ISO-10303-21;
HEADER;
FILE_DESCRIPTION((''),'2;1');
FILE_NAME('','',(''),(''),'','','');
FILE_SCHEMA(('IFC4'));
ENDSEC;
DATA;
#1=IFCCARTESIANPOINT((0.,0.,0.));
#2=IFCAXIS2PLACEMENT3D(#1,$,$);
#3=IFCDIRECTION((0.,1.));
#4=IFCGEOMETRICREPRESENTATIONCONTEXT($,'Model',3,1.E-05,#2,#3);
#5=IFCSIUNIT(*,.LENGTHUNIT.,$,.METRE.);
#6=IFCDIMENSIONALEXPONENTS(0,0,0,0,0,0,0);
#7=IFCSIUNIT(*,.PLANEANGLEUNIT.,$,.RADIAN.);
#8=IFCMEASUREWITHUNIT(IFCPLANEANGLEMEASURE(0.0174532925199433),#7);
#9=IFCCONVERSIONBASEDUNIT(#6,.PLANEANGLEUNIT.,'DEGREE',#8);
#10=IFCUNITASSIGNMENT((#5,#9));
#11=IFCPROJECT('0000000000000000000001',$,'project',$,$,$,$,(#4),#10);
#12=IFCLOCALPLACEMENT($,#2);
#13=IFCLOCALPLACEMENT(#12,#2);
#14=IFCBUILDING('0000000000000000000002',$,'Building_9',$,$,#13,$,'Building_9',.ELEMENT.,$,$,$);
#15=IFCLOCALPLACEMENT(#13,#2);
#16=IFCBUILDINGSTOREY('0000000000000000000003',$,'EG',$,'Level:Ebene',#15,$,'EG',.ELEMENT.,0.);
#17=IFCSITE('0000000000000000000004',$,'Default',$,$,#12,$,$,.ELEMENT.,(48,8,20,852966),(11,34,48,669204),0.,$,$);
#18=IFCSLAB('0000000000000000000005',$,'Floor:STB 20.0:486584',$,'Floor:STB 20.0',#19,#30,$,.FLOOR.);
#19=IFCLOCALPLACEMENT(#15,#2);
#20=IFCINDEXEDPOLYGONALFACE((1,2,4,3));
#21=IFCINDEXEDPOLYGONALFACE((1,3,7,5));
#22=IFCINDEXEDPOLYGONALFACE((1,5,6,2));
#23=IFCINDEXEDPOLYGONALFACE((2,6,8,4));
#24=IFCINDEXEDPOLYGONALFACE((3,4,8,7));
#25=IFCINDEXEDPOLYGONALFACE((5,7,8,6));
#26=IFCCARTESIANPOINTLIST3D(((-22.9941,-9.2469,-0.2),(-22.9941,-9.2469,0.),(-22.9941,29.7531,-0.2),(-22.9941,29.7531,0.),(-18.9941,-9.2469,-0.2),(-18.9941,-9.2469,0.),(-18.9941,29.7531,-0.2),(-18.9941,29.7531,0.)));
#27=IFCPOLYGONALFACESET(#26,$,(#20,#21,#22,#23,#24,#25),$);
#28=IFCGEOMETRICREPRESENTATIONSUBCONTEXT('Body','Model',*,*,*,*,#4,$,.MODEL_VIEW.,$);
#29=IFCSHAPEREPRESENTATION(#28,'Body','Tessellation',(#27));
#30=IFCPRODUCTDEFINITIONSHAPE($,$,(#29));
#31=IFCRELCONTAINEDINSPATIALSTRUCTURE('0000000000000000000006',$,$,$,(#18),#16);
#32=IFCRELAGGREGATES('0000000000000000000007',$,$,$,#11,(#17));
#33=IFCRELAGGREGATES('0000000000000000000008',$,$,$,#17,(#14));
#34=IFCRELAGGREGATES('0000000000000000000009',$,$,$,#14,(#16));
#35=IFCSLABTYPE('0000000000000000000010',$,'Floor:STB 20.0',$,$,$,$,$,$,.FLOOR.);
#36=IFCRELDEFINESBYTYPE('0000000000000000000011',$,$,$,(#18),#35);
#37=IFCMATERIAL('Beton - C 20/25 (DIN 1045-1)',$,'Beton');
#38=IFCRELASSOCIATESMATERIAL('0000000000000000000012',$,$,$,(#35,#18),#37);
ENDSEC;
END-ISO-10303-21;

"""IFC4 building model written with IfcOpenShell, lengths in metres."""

from ifc_helpers import new_model, entity, si_unit, converted_unit, direction, frame, origin, place, context, subcontext, project, spatial, indexed_curve, outline, extrude, material, type_object, element, save


model = new_model("IFC4")

# Units and contexts
model_context = context("Model", 3, precision=1e-05, world=origin(), true_north=direction((0.0, 1.0)))
body_context = subcontext(model_context, "Body", "Model", "MODEL_VIEW")
ifc_project = project(units=[si_unit("LENGTHUNIT", "METRE"), converted_unit("PLANEANGLEUNIT", "DEGREE", entity("IfcPlaneAngleMeasure", 0.0174532925199433), si_unit("PLANEANGLEUNIT", "RADIAN"), dimensions=[0, 0, 0, 0, 0, 0, 0])], contexts=[model_context])

# Site, building, storey
site_placement = place(None, origin())
site = spatial("IfcSite", under=ifc_project, at=site_placement, Name="Default", CompositionType="ELEMENT", RefLatitude=(48, 8, 20, 852966), RefLongitude=(11, 34, 48, 669204), RefElevation=0.0)
building_placement = place(site_placement, origin())
building = spatial("IfcBuilding", under=site, at=building_placement, Name="Building_9", LongName="Building_9", CompositionType="ELEMENT")
storey_placement = place(building_placement, origin())
storey = spatial("IfcBuildingStorey", under=building, at=storey_placement, Name="EG", ObjectType="Level:Ebene", LongName="EG", CompositionType="ELEMENT", Elevation=0.0)

# Slab
ifc_material_1 = material(Name="Beton - C 20/25 (DIN 1045-1)", Category="Beton")
slab_type = type_object("IfcSlabType", Name="Floor:STB 20.0", PredefinedType="FLOOR", material=ifc_material_1)
slab_1_placement = place(storey_placement, origin())
element("IfcSlab", 1, at=slab_1_placement, inside=storey, type_object=slab_type, material=ifc_material_1, Name="Floor:STB 20.0:486584", ObjectType="Floor:STB 20.0", PredefinedType="FLOOR", context=body_context, shape_type="SweptSolid", body=[
    extrude(outline(indexed_curve([(-19.5, -2.0), (19.5, -2.0), (19.5, 2.0), (-19.5, 2.0), (-19.5, -2.0)], self_intersect=False)), frame((-20.9941, 10.2531, 0.0), z_axis=(0.0, 0.0, -1.0), x_axis=(0.0, 1.0, 0.0)), (0.0, 0.0, 1.0), 0.2),
])

save(model, "model.ifc")
